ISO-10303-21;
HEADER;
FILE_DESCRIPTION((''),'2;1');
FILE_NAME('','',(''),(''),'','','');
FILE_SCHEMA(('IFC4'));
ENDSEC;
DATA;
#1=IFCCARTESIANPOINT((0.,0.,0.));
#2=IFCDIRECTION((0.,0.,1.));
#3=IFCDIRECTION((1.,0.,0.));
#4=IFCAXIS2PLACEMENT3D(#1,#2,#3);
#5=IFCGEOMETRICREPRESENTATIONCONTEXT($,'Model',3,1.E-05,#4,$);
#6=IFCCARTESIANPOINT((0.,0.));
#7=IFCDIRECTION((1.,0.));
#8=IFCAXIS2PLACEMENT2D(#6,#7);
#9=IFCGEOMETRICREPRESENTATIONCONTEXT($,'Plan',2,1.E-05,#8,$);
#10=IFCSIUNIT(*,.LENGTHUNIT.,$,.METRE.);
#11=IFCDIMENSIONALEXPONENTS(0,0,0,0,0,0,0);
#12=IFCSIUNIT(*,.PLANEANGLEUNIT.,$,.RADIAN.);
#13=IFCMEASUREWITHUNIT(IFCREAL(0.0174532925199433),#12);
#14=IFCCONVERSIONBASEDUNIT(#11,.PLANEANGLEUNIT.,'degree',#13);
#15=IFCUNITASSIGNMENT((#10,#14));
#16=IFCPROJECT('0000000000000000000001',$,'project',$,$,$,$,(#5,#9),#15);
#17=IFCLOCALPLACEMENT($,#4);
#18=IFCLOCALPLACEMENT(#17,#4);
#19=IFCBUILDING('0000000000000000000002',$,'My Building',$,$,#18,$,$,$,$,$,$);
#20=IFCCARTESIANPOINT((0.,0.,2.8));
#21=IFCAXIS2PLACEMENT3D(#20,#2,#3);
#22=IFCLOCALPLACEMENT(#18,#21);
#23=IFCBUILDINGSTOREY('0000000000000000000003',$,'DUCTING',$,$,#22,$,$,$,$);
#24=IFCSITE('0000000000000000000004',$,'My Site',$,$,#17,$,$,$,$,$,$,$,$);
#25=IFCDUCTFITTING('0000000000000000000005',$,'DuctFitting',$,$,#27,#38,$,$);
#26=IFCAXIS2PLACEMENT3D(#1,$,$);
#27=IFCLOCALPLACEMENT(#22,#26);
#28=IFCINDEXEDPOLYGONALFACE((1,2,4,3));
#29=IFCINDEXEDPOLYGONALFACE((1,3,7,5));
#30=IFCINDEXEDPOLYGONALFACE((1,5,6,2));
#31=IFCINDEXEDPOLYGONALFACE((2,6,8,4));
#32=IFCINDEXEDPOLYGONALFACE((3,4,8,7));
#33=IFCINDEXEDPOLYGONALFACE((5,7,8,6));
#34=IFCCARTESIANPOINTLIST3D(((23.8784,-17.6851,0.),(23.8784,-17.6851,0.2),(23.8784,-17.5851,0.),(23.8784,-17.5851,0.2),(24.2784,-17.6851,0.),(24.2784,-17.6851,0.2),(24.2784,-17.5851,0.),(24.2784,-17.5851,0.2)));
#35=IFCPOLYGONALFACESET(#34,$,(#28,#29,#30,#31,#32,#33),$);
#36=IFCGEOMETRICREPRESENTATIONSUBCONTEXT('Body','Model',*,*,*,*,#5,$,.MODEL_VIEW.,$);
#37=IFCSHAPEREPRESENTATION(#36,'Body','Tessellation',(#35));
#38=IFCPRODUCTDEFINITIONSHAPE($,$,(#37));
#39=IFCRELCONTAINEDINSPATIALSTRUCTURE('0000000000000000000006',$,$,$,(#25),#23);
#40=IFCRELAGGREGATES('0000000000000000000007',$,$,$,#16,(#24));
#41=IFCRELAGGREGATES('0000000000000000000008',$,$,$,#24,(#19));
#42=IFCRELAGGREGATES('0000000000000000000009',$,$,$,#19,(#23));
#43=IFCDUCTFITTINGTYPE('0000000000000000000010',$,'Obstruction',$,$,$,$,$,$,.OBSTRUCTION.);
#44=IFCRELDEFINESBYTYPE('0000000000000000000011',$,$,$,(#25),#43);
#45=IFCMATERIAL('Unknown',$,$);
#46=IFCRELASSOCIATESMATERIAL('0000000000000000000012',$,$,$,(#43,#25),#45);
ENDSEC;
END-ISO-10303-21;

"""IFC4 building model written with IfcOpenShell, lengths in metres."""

from ifc_helpers import new_model, entity, si_unit, converted_unit, frame, origin_with_axes, origin_2d_with_axis, place, context, subcontext, project, spatial, rectangle, extrude, material, material_profile, profile_set, profile_usage, type_object, element, save


model = new_model("IFC4")

# Units and contexts
model_context = context("Model", 3, precision=1e-05, world=origin_with_axes())
plan_context = context("Plan", 2, precision=1e-05, world=origin_2d_with_axis())
body_context = subcontext(model_context, "Body", "Model", "MODEL_VIEW")
ifc_project = project(units=[si_unit("LENGTHUNIT", "METRE"), converted_unit("PLANEANGLEUNIT", "degree", entity("IfcReal", 0.0174532925199433), si_unit("PLANEANGLEUNIT", "RADIAN"), dimensions=[0, 0, 0, 0, 0, 0, 0])], contexts=[model_context, plan_context])

# Site, building, storey
site_placement = place(None, origin_with_axes())
site = spatial("IfcSite", under=ifc_project, at=site_placement, Name="My Site")
building_placement = place(site_placement, origin_with_axes())
building = spatial("IfcBuilding", under=site, at=building_placement, Name="My Building")
storey_placement = place(building_placement, frame((0.0, 0.0, 2.8), z_axis=(0.0, 0.0, 1.0), x_axis=(1.0, 0.0, 0.0)))
storey = spatial("IfcBuildingStorey", under=building, at=storey_placement, Name="DUCTING")

# Shared definitions
ifc_material = material(Name="Unknown")

# Duct fitting
ifc_material_profile_1 = material_profile(ifc_material, rectangle(XDim=0.4, YDim=0.2))
ifc_profile_set_1 = profile_set([ifc_material_profile_1])
duct_fitting_type_1 = type_object("IfcDuctFittingType", Name="Obstruction", PredefinedType="OBSTRUCTION", material=ifc_profile_set_1)
ifc_profile_usage_1 = profile_usage(ifc_profile_set_1, cardinal=5)
duct_fitting_1_placement = place(storey_placement, frame((24.0784, -17.6851, 0.1), z_axis=(0.0, 1.0, 0.0), x_axis=(-1.0, 0.0, 0.0)))
element("IfcDuctFitting", 1, at=duct_fitting_1_placement, inside=storey, type_object=duct_fitting_type_1, material=ifc_profile_usage_1, Name="DuctFitting", context=body_context, shape_type="SweptSolid", body=[
    extrude(rectangle(XDim=0.4, YDim=0.2), origin_with_axes(), (0.0, 0.0, 1.0), 0.1),
])

save(model, "model.ifc")
